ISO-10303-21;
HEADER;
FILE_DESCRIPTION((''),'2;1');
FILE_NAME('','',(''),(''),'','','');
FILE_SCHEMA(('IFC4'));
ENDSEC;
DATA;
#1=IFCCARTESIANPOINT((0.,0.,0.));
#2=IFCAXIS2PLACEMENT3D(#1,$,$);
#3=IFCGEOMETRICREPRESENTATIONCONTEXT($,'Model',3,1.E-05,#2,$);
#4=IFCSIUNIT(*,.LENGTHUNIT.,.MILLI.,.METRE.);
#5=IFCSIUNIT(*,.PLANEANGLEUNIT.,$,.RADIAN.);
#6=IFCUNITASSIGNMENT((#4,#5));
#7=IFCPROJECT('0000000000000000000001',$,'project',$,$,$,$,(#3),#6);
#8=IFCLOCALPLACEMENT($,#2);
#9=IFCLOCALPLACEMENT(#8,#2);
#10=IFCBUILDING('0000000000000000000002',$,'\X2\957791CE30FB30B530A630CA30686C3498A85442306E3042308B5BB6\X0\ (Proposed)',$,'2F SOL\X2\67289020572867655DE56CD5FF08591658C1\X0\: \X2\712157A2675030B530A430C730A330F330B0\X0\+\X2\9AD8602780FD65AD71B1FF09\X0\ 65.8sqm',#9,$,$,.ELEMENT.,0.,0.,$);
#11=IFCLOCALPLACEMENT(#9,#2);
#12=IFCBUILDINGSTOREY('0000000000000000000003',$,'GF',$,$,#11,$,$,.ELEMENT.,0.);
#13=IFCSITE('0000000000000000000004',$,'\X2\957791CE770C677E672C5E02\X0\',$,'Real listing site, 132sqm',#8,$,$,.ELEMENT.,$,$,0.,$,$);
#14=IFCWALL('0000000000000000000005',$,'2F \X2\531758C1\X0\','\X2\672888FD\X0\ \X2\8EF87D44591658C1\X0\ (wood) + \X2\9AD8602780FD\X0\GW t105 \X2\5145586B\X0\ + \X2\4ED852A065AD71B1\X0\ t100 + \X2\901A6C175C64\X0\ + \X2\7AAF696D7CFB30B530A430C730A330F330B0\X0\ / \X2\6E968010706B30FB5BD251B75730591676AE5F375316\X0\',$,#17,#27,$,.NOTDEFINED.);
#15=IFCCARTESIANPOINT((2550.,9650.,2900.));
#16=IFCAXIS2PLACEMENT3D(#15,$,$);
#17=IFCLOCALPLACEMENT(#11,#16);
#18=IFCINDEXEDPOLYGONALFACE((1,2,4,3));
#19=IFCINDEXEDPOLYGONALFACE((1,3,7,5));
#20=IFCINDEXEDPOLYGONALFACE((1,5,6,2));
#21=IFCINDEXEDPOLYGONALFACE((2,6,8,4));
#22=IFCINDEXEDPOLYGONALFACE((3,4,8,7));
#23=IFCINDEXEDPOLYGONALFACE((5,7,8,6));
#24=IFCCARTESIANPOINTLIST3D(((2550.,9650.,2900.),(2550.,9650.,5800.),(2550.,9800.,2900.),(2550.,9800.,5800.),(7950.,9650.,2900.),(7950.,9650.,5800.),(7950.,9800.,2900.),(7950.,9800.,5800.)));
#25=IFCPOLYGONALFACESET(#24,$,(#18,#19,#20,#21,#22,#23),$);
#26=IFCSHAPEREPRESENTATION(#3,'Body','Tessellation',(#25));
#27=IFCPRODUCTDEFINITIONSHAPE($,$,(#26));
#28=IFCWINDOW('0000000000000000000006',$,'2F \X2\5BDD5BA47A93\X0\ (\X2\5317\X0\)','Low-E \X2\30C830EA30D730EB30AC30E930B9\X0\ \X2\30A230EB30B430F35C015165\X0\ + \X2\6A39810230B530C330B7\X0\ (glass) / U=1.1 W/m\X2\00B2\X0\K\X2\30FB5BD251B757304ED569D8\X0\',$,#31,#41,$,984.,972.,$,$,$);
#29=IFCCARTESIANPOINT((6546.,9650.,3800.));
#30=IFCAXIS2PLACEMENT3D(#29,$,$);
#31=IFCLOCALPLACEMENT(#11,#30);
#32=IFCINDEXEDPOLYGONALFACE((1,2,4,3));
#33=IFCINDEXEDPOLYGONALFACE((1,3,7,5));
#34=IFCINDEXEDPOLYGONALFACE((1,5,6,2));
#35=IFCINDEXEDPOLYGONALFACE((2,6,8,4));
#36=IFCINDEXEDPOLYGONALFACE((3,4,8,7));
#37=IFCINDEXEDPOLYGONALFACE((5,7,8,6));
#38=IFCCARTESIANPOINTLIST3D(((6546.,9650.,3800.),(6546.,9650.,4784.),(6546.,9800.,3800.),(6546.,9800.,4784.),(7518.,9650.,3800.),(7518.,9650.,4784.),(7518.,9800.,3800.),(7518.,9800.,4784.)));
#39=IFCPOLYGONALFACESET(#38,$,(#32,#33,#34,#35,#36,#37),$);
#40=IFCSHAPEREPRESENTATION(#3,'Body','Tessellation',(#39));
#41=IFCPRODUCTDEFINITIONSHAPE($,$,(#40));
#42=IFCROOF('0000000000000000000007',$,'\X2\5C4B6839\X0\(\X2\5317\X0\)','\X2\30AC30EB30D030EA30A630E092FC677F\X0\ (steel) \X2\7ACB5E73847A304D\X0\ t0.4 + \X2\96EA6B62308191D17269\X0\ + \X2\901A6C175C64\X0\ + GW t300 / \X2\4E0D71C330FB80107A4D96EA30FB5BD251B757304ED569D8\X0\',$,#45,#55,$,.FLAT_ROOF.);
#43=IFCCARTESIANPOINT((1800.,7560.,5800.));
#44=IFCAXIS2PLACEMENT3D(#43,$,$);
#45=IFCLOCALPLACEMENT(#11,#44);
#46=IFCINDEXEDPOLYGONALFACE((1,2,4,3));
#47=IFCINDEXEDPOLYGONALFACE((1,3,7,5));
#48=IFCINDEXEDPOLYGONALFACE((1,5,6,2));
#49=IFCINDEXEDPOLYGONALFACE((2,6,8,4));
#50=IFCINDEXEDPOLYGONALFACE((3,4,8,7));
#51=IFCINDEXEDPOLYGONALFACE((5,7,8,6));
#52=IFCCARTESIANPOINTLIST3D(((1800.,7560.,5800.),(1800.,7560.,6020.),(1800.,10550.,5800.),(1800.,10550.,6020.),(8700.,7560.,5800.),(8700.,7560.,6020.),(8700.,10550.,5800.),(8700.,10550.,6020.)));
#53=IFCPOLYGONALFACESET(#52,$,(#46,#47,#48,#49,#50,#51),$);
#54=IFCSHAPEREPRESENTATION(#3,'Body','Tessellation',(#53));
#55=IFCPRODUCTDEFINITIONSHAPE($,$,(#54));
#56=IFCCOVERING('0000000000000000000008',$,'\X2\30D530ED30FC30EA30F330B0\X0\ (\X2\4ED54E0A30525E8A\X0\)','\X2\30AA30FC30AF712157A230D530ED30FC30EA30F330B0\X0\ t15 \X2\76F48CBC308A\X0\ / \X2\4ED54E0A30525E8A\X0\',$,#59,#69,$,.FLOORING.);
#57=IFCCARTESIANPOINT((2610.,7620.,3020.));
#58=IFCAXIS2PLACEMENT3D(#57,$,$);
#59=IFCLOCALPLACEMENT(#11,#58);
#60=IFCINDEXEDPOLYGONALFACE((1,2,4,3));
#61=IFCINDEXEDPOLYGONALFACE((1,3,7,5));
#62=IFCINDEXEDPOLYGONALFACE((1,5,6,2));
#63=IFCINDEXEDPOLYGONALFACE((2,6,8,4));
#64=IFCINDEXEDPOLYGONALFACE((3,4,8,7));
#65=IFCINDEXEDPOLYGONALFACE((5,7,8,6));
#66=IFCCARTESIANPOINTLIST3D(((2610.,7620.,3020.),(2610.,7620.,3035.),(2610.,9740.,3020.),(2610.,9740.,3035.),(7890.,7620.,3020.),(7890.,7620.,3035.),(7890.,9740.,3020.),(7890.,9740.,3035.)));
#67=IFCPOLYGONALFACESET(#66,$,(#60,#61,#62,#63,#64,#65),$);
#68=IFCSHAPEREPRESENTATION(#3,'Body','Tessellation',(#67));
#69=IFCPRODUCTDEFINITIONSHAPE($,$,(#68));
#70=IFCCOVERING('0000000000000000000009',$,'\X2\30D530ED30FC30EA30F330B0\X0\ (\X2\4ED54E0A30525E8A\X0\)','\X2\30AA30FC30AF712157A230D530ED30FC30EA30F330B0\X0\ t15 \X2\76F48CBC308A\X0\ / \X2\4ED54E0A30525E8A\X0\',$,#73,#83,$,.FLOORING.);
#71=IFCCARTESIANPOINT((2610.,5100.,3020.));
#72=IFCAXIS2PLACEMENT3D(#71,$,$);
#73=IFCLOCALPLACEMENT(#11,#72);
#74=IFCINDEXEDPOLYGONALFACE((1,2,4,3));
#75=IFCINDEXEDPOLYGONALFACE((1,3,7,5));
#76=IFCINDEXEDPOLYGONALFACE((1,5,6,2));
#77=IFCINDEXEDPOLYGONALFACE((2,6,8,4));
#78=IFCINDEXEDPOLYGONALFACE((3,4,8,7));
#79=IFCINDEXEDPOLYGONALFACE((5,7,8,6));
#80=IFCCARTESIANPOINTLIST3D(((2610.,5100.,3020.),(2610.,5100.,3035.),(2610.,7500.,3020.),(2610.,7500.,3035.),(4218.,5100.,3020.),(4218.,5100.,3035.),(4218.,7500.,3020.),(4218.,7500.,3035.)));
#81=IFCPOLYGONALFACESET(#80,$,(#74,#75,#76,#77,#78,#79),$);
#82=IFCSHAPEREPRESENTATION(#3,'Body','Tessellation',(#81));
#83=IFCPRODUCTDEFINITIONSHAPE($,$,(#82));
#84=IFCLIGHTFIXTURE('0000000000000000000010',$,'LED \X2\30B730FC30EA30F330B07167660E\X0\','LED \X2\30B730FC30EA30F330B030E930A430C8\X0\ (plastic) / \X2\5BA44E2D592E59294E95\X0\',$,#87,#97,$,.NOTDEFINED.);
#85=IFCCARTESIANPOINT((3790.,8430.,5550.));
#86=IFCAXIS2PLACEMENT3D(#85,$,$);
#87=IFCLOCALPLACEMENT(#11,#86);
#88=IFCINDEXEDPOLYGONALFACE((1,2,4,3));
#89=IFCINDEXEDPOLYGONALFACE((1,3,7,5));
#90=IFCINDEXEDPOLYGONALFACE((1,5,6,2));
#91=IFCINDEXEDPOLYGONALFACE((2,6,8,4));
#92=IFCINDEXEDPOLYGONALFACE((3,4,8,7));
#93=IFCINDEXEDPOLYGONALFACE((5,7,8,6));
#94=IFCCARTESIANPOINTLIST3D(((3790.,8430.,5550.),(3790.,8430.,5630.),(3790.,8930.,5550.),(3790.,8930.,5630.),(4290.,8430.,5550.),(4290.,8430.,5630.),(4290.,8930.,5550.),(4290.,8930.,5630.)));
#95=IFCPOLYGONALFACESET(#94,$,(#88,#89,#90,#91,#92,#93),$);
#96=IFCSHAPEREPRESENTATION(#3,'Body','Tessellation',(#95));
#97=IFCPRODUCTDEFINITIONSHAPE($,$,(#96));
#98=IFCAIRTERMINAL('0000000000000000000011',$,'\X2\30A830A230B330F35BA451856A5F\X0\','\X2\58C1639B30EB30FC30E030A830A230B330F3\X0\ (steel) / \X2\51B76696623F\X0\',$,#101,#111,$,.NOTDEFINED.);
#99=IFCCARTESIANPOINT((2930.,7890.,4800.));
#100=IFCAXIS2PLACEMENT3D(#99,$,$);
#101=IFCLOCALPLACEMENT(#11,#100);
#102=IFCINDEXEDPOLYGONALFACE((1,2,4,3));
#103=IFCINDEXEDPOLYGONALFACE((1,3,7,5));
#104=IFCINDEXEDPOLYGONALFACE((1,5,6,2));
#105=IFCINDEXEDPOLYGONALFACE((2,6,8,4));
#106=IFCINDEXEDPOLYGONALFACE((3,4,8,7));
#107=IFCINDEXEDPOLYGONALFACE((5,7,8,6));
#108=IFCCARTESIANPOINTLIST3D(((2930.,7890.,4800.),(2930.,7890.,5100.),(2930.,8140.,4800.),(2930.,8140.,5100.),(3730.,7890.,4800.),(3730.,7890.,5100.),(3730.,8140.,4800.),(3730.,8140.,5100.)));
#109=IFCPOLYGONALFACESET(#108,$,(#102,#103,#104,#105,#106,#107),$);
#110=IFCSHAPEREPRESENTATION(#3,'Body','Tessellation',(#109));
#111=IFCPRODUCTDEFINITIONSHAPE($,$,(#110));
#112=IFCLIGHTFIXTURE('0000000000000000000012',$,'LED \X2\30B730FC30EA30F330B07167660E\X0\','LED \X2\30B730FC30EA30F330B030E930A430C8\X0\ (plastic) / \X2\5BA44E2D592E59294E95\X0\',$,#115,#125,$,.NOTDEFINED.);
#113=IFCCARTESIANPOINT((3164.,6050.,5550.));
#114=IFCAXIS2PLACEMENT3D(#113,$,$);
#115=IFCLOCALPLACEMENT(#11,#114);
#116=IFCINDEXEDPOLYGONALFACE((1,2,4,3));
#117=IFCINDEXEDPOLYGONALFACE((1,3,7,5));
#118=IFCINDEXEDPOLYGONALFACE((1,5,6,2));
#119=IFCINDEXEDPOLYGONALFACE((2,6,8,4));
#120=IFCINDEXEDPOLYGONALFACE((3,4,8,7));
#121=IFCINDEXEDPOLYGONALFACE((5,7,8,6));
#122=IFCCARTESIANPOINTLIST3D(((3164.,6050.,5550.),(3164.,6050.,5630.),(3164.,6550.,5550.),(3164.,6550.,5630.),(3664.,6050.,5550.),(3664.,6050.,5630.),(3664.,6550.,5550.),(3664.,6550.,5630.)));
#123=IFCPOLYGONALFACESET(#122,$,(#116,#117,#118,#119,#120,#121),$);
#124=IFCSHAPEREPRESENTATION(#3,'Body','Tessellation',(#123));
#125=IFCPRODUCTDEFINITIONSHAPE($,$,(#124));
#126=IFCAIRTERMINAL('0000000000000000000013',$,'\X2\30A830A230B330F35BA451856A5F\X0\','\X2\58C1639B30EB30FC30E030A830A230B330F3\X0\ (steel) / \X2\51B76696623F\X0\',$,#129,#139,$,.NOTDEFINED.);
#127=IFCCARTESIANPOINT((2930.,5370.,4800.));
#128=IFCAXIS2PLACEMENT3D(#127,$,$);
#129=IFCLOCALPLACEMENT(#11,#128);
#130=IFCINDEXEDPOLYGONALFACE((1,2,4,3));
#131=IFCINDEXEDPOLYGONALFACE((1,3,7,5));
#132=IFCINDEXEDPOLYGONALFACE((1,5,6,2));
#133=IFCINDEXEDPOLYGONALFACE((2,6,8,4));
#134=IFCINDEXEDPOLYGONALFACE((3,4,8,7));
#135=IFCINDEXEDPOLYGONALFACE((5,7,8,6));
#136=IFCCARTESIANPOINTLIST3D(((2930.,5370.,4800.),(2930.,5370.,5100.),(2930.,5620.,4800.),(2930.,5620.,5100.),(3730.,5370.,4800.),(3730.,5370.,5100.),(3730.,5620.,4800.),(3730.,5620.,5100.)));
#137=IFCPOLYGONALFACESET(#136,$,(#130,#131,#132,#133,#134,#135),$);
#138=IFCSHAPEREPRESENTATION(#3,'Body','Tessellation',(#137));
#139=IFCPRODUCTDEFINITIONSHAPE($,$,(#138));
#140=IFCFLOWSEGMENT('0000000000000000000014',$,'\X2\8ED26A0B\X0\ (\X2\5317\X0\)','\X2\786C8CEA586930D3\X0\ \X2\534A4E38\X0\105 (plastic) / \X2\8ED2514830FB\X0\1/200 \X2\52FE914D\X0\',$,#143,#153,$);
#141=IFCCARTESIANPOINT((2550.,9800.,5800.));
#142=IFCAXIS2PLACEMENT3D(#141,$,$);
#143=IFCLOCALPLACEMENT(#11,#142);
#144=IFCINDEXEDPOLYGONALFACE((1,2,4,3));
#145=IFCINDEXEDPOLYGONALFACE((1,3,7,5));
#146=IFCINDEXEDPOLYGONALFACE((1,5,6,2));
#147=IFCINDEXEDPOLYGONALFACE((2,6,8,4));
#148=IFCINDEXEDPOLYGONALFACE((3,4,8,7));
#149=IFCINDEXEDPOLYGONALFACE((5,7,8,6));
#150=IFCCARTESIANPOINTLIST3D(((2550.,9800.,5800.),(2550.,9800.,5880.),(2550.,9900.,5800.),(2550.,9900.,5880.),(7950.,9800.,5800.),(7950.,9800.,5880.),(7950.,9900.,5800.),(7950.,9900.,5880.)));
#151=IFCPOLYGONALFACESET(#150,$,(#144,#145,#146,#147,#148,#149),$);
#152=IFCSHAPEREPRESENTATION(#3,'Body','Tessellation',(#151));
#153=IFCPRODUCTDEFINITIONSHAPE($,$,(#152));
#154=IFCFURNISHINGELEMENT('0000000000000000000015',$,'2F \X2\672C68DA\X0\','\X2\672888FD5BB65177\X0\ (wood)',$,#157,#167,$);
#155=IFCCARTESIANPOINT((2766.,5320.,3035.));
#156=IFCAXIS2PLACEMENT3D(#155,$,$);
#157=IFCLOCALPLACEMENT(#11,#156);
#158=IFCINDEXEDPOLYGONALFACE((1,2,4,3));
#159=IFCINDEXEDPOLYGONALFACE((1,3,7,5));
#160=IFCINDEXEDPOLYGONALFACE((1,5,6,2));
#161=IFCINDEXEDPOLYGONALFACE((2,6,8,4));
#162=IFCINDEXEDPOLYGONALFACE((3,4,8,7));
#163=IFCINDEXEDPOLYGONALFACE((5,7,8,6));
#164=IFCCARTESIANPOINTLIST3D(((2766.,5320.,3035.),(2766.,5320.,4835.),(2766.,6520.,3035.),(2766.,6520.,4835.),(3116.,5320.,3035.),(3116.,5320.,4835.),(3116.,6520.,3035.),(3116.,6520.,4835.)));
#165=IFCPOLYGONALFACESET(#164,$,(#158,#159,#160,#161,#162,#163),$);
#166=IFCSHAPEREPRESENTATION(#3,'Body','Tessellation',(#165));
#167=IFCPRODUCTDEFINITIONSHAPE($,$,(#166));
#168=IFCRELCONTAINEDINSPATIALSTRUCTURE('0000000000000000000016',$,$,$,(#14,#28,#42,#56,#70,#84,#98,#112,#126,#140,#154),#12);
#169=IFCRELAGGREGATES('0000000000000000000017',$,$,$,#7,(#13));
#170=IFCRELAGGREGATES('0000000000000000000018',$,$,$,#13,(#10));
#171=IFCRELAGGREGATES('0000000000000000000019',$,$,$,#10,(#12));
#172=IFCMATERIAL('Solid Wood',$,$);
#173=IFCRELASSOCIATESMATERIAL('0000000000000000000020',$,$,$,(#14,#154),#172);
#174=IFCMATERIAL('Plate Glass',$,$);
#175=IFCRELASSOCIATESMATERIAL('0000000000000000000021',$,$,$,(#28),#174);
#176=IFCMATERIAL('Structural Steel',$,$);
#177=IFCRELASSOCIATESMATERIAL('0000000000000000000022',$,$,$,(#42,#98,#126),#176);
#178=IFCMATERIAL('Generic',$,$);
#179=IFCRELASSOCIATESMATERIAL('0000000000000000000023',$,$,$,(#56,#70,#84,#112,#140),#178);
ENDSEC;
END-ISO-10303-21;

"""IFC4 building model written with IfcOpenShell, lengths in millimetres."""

from ifc_helpers import new_model, si_unit, frame, frame_2d, origin, place, context, project, spatial, rectangle, extrude, material, element, fill, save


model = new_model("IFC4")

# Units and contexts
model_context = context("Model", 3, precision=1e-05, world=origin())
ifc_project = project(units=[si_unit("LENGTHUNIT", "METRE", prefix="MILLI"), si_unit("PLANEANGLEUNIT", "RADIAN")], contexts=[model_context])

# Site, building, storey
site_placement = place(None, origin())
site = spatial("IfcSite", under=ifc_project, at=site_placement, Name="長野県松本市", ObjectType="Real listing site, 132sqm", CompositionType="ELEMENT", RefElevation=0.0)
building_placement = place(site_placement, origin())
building = spatial("IfcBuilding", under=site, at=building_placement, Name="長野・サウナと水風呂のある家 (Proposed)", ObjectType="2F SOL木造在来工法（外壁: 無垢材サイディング+高性能断熱） 65.8sqm", CompositionType="ELEMENT", ElevationOfRefHeight=0.0, ElevationOfTerrain=0.0)
storey_placement = place(building_placement, origin())
storey = spatial("IfcBuildingStorey", under=building, at=storey_placement, Name="GF", CompositionType="ELEMENT", Elevation=0.0)

# Shared definitions
ifc_material_1 = material(Name="Solid Wood")

# Wall, opening, window
wall_placement = place(storey_placement, frame((2550.0, 9650.0, 2900.0)))
wall = element("IfcWall", 1, at=wall_placement, inside=storey, material=ifc_material_1, Name="2F 北壁", Description="木製 軸組外壁 (wood) + 高性能GW t105 充填 + 付加断熱 t100 + 通気層 + 窯業系サイディング / 準耐火・寒冷地外皮強化", PredefinedType="NOTDEFINED", context=model_context, shape_type="SweptSolid", body=[
    extrude(rectangle(XDim=5400.0, YDim=150.0, at=frame_2d((2700.0, 75.0))), frame((2550.0, 9650.0, 2900.0)), (0.0, 0.0, 1.0), 2900.0),
])
opening_placement = place(storey_placement, frame((6546.0, 9650.0, 3800.0)))
opening = element("IfcOpeningElement", 2, at=opening_placement, cuts=wall, PredefinedType="NOTDEFINED", context=model_context, shape_type="SweptSolid", body=[
    extrude(rectangle(XDim=972.0, YDim=150.0, at=frame_2d((486.0, 75.0))), frame((6546.0, 9650.0, 3800.0)), (0.0, 0.0, 1.0), 984.0),
])
ifc_material_2 = material(Name="Plate Glass")
window_placement = place(storey_placement, frame((6546.0, 9650.0, 3800.0)))
window = element("IfcWindow", 3, at=window_placement, inside=storey, material=ifc_material_2, Name="2F 寝室窓 (北)", Description="Low-E トリプルガラス アルゴン封入 + 樹脂サッシ (glass) / U=1.1 W/m²K・寒冷地仕様", OverallHeight=984.0, OverallWidth=972.0, context=model_context, shape_type="SweptSolid", body=[
    extrude(rectangle(XDim=972.0, YDim=150.0, at=frame_2d((486.0, 75.0))), frame((6546.0, 9650.0, 3800.0)), (0.0, 0.0, 1.0), 984.0),
])
fill(opening, window)

# Roof
ifc_material_3 = material(Name="Structural Steel")
for number, where, name in (
    (4, (1800.0, 7560.0, 5800.0), "屋根(北)"),
):
    element("IfcRoof", number, at=place(storey_placement, frame(where)), inside=storey, material=ifc_material_3, Name=name, Description="ガルバリウム鋼板 (steel) 立平葺き t0.4 + 雪止め金物 + 通気層 + GW t300 / 不燃・耐積雪・寒冷地仕様", PredefinedType="FLAT_ROOF", context=model_context, shape_type="SweptSolid", body=[
        extrude(rectangle(XDim=6900.0, YDim=2990.0, at=frame_2d((3450.0, 1495.0))), frame((1800.0, 7560.0, 5800.0)), (0.0, 0.0, 1.0), 220.0),
    ])

# Coverings
ifc_material_4 = material(Name="Generic")
covering_1_placement = place(storey_placement, frame((2610.0, 7620.0, 3020.0)))
element("IfcCovering", 5, at=covering_1_placement, inside=storey, material=ifc_material_4, Name="フローリング (仕上げ床)", Description="オーク無垢フローリング t15 直貼り / 仕上げ床", PredefinedType="FLOORING", context=model_context, shape_type="SweptSolid", body=[
    extrude(rectangle(XDim=5280.0, YDim=2120.0, at=frame_2d((2640.0, 1060.0))), frame((2610.0, 7620.0, 3020.0)), (0.0, 0.0, 1.0), 15.0),
])
covering_2_placement = place(storey_placement, frame((2610.0, 5100.0, 3020.0)))
element("IfcCovering", 6, at=covering_2_placement, inside=storey, material=ifc_material_4, Name="フローリング (仕上げ床)", Description="オーク無垢フローリング t15 直貼り / 仕上げ床", PredefinedType="FLOORING", context=model_context, shape_type="SweptSolid", body=[
    extrude(rectangle(XDim=1608.0, YDim=2400.0, at=frame_2d((804.0, 1200.0))), frame((2610.0, 5100.0, 3020.0)), (0.0, 0.0, 1.0), 15.0),
])

# Light fixture
light_fixture_1_placement = place(storey_placement, frame((3790.0, 8430.0, 5550.0)))
element("IfcLightFixture", 7, at=light_fixture_1_placement, inside=storey, material=ifc_material_4, Name="LED シーリング照明", Description="LED シーリングライト (plastic) / 室中央天井", PredefinedType="NOTDEFINED", context=model_context, shape_type="SweptSolid", body=[
    extrude(rectangle(XDim=500.0, YDim=500.0, at=frame_2d((250.0, 250.0))), frame((3790.0, 8430.0, 5550.0)), (0.0, 0.0, 1.0), 80.0),
])

# Air terminal
air_terminal_1_placement = place(storey_placement, frame((2930.0, 7890.0, 4800.0)))
element("IfcAirTerminal", 8, at=air_terminal_1_placement, inside=storey, material=ifc_material_3, Name="エアコン室内機", Description="壁掛ルームエアコン (steel) / 冷暖房", PredefinedType="NOTDEFINED", context=model_context, shape_type="SweptSolid", body=[
    extrude(rectangle(XDim=800.0, YDim=250.0, at=frame_2d((400.0, 125.0))), frame((2930.0, 7890.0, 4800.0)), (0.0, 0.0, 1.0), 300.0),
])

# Light fixture
light_fixture_2_placement = place(storey_placement, frame((3164.0, 6050.0, 5550.0)))
element("IfcLightFixture", 9, at=light_fixture_2_placement, inside=storey, material=ifc_material_4, Name="LED シーリング照明", Description="LED シーリングライト (plastic) / 室中央天井", PredefinedType="NOTDEFINED", context=model_context, shape_type="SweptSolid", body=[
    extrude(rectangle(XDim=500.0, YDim=500.0, at=frame_2d((250.0, 250.0))), frame((3164.0, 6050.0, 5550.0)), (0.0, 0.0, 1.0), 80.0),
])

# Air terminal
air_terminal_2_placement = place(storey_placement, frame((2930.0, 5370.0, 4800.0)))
element("IfcAirTerminal", 10, at=air_terminal_2_placement, inside=storey, material=ifc_material_3, Name="エアコン室内機", Description="壁掛ルームエアコン (steel) / 冷暖房", PredefinedType="NOTDEFINED", context=model_context, shape_type="SweptSolid", body=[
    extrude(rectangle(XDim=800.0, YDim=250.0, at=frame_2d((400.0, 125.0))), frame((2930.0, 5370.0, 4800.0)), (0.0, 0.0, 1.0), 300.0),
])

# Flow segment
flow_segment_placement = place(storey_placement, frame((2550.0, 9800.0, 5800.0)))
element("IfcFlowSegment", 11, at=flow_segment_placement, inside=storey, material=ifc_material_4, Name="軒樋 (北)", Description="硬質塩ビ 半丸105 (plastic) / 軒先・1/200 勾配", context=model_context, shape_type="SweptSolid", body=[
    extrude(rectangle(XDim=5400.0, YDim=100.0, at=frame_2d((2700.0, 50.0))), frame((2550.0, 9800.0, 5800.0)), (0.0, 0.0, 1.0), 80.0),
])

# Furnishing element
furnishing_placement = place(storey_placement, frame((2766.0, 5320.0, 3035.0)))
element("IfcFurnishingElement", 12, at=furnishing_placement, inside=storey, material=ifc_material_1, Name="2F 本棚", Description="木製家具 (wood)", context=model_context, shape_type="SweptSolid", body=[
    extrude(rectangle(XDim=350.0, YDim=1200.0, at=frame_2d((175.0, 600.0))), frame((2766.0, 5320.0, 3035.0)), (0.0, 0.0, 1.0), 1800.0),
])

save(model, "model.ifc")
